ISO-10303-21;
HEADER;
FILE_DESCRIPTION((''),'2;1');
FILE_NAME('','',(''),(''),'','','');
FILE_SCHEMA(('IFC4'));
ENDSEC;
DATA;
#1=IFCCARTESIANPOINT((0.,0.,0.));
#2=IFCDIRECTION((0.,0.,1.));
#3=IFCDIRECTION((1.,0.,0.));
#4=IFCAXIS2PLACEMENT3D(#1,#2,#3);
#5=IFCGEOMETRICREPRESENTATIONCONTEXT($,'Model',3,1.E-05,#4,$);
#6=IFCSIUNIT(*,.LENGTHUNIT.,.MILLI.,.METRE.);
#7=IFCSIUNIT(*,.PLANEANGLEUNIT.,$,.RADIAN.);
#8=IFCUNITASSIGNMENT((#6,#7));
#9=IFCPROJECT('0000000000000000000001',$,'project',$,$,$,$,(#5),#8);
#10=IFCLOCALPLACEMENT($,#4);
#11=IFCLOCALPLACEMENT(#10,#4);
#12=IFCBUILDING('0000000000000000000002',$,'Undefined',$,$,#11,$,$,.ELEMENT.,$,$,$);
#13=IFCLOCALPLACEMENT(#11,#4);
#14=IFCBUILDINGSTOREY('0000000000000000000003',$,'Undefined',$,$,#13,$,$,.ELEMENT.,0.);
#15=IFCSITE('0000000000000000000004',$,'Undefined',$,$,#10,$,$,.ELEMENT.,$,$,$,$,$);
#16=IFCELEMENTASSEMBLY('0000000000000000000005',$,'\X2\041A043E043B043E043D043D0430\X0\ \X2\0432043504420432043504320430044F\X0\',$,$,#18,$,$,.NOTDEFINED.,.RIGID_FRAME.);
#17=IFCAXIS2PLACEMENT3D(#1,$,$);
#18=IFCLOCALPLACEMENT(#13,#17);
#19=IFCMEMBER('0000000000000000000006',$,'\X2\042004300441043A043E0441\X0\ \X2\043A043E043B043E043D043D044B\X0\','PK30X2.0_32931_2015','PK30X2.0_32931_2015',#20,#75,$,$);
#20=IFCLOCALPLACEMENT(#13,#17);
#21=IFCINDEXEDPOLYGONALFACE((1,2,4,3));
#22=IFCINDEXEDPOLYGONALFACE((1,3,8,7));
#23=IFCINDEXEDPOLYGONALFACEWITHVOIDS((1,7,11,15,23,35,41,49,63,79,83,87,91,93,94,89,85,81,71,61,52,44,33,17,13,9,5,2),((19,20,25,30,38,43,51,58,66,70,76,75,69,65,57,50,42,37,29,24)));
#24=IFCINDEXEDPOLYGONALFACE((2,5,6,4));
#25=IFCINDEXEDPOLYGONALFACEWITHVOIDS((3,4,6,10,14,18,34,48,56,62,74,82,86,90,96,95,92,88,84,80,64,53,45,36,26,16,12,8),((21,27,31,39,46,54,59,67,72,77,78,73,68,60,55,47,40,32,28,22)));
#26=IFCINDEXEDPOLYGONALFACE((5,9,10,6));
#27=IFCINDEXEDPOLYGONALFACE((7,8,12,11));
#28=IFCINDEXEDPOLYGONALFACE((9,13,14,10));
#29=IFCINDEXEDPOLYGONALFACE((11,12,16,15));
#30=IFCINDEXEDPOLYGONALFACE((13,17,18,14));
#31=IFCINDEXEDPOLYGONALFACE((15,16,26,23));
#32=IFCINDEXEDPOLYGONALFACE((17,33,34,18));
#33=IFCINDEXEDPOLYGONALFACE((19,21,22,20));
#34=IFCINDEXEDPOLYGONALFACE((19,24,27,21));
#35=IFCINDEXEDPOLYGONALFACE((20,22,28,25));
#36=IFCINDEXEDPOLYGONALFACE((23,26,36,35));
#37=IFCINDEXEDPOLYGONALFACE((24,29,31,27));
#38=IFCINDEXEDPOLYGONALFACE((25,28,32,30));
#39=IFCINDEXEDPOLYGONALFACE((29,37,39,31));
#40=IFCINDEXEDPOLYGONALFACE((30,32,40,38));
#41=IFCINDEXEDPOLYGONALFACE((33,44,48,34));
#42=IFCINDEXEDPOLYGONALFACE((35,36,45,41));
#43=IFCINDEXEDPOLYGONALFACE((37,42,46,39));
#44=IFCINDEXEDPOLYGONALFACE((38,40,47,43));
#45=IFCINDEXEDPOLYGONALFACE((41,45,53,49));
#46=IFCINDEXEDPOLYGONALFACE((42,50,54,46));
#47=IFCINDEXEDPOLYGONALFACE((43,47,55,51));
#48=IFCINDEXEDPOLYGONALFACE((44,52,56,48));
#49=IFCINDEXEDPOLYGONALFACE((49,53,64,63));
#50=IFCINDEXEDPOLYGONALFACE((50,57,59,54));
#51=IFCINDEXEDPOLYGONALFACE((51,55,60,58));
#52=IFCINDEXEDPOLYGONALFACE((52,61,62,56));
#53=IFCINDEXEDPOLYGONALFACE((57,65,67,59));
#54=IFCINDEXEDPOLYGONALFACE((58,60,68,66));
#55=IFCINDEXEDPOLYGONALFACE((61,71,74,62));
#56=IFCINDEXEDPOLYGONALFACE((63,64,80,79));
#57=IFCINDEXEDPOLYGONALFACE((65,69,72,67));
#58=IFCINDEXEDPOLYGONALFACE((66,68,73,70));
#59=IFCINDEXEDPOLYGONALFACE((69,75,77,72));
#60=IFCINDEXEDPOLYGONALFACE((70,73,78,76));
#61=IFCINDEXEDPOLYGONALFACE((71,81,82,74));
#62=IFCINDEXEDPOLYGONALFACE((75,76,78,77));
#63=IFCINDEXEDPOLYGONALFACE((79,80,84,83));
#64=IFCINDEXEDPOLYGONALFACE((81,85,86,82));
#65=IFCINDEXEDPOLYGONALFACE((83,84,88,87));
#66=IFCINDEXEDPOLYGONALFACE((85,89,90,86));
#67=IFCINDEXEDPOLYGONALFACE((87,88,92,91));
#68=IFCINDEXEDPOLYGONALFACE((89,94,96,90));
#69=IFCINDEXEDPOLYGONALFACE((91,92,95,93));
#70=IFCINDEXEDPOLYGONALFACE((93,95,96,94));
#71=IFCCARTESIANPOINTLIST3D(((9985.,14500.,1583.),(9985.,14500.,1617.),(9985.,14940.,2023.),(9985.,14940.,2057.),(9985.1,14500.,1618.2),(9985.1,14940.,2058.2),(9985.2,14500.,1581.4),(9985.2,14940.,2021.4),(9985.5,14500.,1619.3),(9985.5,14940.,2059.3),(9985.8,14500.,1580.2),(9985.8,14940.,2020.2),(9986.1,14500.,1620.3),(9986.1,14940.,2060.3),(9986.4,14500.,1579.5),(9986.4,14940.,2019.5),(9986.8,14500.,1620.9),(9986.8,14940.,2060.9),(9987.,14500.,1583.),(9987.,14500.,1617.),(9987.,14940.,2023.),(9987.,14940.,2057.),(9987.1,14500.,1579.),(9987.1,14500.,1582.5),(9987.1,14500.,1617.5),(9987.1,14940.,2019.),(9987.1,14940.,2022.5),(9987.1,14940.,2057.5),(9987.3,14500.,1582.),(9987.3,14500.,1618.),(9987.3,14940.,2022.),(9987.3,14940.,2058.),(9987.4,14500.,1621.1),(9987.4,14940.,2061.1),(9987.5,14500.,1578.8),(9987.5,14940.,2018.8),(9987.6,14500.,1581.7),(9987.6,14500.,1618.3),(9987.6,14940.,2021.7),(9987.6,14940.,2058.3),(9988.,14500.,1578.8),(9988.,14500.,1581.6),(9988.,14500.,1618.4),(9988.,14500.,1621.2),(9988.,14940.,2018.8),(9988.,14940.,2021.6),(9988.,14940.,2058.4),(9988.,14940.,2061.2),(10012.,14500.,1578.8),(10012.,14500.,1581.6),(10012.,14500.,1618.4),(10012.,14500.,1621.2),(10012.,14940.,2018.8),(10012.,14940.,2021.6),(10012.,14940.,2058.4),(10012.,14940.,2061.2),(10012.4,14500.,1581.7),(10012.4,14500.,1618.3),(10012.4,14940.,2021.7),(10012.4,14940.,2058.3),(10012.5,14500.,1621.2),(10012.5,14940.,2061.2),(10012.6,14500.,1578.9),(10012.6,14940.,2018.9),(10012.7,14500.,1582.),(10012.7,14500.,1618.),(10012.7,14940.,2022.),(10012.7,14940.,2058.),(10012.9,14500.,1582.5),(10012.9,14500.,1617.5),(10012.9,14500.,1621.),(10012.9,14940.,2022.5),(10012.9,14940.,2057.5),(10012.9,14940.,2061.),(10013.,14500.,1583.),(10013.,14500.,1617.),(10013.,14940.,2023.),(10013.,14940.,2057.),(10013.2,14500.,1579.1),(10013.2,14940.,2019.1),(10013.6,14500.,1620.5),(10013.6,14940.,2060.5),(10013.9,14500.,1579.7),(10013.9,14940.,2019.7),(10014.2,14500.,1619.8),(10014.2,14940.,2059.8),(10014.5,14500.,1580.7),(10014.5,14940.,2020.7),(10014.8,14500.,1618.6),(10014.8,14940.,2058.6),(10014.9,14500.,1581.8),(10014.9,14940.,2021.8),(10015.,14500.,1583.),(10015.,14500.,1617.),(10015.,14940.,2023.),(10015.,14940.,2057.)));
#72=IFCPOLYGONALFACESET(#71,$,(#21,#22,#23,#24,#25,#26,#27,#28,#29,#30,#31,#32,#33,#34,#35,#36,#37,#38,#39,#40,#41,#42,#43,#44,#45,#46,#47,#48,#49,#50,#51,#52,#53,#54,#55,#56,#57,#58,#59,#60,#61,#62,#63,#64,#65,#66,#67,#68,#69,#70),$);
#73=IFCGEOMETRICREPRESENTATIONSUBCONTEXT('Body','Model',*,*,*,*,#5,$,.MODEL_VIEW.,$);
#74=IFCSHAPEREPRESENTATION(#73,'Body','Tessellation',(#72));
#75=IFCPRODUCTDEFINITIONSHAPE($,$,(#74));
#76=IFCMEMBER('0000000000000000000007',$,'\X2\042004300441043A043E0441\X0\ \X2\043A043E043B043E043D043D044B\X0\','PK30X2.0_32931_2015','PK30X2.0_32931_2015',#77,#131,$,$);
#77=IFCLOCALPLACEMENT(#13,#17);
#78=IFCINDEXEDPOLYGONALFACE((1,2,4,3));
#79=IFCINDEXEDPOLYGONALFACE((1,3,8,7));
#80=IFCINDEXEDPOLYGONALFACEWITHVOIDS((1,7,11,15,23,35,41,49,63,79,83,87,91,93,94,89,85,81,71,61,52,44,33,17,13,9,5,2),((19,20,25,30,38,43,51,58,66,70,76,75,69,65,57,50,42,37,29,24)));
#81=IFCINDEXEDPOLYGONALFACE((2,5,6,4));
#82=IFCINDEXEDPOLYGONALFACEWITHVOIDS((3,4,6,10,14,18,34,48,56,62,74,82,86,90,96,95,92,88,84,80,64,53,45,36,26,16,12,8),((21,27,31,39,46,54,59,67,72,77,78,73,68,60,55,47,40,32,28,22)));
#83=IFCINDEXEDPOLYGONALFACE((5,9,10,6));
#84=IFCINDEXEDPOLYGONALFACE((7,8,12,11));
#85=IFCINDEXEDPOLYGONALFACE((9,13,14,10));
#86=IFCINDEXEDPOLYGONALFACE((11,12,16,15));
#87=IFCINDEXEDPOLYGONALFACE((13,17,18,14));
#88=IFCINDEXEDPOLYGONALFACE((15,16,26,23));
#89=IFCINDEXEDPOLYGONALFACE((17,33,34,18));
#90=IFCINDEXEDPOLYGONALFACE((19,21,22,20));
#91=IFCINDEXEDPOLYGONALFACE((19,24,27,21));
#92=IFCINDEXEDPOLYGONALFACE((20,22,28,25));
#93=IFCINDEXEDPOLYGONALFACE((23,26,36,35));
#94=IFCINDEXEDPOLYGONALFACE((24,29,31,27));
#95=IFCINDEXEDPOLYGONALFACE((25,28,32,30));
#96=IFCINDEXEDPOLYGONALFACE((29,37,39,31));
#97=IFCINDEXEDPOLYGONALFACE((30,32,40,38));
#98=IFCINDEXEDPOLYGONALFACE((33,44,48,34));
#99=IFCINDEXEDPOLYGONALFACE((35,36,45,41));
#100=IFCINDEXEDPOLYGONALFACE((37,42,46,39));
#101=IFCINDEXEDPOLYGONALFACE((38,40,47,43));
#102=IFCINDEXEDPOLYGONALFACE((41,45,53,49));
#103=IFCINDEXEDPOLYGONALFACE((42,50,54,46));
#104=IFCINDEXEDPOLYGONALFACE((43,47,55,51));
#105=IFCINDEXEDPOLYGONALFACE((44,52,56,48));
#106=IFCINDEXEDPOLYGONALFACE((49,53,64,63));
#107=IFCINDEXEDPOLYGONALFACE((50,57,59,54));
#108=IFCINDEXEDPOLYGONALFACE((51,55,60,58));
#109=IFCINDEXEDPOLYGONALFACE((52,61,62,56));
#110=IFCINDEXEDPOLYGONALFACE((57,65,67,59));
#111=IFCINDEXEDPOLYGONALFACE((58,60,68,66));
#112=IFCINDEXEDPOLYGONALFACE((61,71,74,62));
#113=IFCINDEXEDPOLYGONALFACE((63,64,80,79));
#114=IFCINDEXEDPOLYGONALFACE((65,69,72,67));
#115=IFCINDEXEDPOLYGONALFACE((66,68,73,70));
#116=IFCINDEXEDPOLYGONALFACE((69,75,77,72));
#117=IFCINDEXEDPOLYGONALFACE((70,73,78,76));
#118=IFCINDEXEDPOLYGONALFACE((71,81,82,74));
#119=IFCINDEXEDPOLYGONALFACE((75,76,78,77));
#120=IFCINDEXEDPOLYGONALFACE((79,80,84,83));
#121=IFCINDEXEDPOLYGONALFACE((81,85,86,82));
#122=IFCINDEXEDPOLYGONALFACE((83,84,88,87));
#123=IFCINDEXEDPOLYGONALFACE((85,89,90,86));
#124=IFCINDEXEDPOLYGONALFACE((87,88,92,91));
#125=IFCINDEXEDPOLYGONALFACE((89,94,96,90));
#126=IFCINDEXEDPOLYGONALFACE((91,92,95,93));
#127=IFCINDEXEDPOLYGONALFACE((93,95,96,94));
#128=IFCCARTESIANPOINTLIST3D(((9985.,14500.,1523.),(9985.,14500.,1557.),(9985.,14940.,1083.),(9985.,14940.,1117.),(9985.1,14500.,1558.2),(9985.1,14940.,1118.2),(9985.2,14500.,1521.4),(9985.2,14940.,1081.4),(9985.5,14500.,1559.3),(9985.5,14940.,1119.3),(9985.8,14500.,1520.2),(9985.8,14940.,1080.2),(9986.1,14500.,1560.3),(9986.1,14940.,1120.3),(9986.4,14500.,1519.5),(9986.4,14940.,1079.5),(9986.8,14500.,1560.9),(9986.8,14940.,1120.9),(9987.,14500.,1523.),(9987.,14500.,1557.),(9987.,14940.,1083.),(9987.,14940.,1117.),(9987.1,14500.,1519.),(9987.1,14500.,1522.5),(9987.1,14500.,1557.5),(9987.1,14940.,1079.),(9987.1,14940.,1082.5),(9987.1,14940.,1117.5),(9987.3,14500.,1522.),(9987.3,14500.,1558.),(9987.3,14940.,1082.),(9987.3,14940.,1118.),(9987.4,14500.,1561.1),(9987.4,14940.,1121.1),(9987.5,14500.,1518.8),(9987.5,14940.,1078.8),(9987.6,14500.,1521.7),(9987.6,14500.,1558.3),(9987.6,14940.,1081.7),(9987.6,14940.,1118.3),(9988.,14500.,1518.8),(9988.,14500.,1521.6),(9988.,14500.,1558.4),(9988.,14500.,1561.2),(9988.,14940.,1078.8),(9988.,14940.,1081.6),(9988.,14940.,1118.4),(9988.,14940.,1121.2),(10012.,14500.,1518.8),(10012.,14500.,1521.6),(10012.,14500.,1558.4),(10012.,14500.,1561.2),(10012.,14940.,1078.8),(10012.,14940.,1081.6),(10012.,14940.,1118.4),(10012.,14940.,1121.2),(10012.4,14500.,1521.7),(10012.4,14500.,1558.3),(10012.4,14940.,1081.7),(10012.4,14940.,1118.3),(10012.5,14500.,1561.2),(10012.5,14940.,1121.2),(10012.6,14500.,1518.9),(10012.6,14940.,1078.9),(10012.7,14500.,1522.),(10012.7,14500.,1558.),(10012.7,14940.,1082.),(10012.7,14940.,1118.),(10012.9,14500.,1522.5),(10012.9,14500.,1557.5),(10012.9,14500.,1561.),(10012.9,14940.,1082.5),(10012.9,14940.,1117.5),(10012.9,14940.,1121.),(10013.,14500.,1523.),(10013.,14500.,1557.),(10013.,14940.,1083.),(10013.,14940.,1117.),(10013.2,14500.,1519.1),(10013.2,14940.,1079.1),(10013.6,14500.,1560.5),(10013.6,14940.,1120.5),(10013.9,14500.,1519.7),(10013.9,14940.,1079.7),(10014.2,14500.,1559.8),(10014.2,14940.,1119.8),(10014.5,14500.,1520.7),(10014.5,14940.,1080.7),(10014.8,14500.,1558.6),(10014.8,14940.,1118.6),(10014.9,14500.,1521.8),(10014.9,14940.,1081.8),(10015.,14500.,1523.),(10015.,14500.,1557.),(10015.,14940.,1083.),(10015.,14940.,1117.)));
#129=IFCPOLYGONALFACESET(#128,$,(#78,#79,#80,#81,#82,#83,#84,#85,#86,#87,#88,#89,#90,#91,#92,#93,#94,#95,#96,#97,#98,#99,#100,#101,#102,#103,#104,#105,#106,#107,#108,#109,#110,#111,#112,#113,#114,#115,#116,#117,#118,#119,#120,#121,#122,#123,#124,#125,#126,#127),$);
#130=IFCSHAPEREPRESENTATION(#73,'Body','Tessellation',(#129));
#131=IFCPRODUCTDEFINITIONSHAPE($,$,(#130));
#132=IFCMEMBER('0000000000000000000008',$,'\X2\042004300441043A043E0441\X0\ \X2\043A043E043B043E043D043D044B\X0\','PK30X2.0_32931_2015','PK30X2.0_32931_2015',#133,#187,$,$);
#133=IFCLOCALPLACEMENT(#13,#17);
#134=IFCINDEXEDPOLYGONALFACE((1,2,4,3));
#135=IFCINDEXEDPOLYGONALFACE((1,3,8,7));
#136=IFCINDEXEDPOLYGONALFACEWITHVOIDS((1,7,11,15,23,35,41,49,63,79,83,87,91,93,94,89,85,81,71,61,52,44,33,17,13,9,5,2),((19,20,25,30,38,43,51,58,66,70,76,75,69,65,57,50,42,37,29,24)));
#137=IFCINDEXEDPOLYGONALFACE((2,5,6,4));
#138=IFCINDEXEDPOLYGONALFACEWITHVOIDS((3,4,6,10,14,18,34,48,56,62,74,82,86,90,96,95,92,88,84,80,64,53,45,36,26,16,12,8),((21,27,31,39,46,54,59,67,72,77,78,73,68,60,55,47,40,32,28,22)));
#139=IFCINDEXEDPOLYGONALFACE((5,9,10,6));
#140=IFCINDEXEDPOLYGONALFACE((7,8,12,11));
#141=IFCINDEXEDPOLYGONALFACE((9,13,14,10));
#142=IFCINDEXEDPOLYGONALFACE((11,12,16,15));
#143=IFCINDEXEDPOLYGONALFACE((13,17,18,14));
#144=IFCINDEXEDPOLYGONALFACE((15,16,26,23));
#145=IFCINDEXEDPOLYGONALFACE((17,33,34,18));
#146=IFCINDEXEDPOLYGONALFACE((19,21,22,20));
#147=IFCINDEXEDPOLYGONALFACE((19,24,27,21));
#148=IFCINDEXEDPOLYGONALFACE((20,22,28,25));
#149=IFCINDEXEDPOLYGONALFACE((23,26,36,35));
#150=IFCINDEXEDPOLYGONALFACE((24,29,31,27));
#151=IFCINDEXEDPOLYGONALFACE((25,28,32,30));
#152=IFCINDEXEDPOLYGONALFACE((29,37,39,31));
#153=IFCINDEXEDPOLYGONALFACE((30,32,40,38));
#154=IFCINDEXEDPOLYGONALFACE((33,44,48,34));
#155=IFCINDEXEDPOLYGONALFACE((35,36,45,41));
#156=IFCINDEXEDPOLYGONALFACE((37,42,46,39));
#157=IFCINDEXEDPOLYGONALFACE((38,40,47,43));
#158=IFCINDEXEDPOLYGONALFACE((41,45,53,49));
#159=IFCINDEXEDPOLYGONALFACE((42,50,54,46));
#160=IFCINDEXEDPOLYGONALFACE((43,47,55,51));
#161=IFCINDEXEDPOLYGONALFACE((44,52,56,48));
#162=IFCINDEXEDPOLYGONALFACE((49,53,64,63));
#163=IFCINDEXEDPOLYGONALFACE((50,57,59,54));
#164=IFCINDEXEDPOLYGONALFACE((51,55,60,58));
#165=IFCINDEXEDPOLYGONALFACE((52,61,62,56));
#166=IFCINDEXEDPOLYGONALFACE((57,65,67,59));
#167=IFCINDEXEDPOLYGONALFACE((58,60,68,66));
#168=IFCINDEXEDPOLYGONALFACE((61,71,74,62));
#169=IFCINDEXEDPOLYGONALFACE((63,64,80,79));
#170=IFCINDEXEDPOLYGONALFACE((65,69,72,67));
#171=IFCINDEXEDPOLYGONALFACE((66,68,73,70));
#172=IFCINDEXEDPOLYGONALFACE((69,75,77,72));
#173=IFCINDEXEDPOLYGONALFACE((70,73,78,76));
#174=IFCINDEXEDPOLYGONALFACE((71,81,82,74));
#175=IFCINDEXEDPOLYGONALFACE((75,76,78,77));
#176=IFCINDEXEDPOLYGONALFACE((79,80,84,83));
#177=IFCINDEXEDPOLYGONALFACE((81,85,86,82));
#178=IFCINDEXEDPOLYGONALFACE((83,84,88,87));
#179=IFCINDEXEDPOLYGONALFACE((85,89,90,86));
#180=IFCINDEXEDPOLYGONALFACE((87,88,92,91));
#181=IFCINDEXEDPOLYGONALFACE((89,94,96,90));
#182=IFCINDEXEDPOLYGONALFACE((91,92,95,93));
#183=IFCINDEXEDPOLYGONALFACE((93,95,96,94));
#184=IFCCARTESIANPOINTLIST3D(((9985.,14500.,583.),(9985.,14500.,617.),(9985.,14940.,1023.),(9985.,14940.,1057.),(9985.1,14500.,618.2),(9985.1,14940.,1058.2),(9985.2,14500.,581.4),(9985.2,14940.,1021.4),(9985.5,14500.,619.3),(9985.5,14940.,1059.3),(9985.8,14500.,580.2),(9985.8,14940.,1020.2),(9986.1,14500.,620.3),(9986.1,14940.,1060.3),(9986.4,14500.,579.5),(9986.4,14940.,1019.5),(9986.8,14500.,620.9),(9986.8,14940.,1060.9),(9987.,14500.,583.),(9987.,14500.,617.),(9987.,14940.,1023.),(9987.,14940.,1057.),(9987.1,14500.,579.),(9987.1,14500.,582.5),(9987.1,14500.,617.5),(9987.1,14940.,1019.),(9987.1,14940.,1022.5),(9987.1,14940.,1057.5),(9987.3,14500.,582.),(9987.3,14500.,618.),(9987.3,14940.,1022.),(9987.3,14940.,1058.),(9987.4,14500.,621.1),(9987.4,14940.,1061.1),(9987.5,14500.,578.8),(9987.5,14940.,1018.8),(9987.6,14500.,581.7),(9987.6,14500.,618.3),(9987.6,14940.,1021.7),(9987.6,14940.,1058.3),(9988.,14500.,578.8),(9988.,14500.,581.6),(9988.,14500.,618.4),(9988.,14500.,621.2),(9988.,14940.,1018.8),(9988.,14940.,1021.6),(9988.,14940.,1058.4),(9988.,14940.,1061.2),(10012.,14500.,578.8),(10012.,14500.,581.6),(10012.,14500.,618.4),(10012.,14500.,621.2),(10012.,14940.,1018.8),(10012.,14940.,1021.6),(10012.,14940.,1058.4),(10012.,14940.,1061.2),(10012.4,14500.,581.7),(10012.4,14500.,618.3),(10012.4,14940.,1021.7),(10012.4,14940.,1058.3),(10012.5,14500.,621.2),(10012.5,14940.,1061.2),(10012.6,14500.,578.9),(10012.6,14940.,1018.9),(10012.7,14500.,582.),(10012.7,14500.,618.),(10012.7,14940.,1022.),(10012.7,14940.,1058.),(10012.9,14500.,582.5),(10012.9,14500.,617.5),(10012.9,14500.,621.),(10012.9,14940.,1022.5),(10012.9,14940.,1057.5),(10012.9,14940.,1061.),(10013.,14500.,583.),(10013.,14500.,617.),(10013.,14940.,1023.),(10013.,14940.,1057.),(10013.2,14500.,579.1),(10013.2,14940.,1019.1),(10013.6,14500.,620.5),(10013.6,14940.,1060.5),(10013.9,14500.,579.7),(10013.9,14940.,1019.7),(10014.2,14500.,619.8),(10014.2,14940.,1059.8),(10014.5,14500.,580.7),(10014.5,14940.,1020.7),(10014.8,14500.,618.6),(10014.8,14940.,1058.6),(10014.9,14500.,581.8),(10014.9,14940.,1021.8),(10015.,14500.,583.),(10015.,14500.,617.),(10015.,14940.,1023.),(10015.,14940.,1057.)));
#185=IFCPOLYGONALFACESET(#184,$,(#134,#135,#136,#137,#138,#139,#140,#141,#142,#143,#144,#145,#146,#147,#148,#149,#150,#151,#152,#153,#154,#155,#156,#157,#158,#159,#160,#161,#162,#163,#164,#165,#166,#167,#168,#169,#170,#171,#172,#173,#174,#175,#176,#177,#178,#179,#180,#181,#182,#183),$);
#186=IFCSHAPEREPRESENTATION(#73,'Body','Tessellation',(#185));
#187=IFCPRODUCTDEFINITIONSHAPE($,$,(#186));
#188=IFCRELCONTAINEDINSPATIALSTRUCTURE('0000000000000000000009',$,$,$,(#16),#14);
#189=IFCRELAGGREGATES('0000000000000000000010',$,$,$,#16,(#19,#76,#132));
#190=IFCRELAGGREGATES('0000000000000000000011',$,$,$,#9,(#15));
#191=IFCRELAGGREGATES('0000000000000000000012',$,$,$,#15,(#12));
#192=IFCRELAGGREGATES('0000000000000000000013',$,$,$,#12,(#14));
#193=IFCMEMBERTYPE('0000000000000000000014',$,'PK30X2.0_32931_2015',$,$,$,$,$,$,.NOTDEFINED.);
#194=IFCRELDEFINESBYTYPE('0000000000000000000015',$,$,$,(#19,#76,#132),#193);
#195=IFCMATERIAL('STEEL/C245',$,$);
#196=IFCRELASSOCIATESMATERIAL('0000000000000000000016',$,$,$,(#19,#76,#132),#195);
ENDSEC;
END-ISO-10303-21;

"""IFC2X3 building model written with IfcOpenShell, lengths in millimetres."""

from ifc_helpers import new_model, si_unit, frame, origin_with_axes, origin_2d_with_axis, place, context, subcontext, project, spatial, hollow_rectangle, extrude, clip, halfspace, material, type_object, element, aggregate, save


model = new_model("IFC2X3")

# Units and contexts
model_context = context("Model", 3, precision=1e-05, world=origin_with_axes())
body_context = subcontext(model_context, "Body", "Model", "MODEL_VIEW")
ifc_project = project(units=[si_unit("LENGTHUNIT", "METRE", prefix="MILLI"), si_unit("PLANEANGLEUNIT", "RADIAN")], contexts=[model_context])

# Site, building, storey
site_placement = place(None, origin_with_axes())
site = spatial("IfcSite", under=ifc_project, at=site_placement, Name="Undefined", CompositionType="ELEMENT")
building_placement = place(site_placement, origin_with_axes())
building = spatial("IfcBuilding", under=site, at=building_placement, Name="Undefined", CompositionType="ELEMENT")
storey_placement = place(building_placement, origin_with_axes())
storey = spatial("IfcBuildingStorey", under=building, at=storey_placement, Name="Undefined", CompositionType="ELEMENT", Elevation=0.0)

# Element assembly
assembly_1_placement = place(storey_placement, origin_with_axes())
assembly_1 = element("IfcElementAssembly", 1, at=assembly_1_placement, inside=storey, Name="Колонна ветвевая", AssemblyPlace="NOTDEFINED", PredefinedType="RIGID_FRAME")
ifc_material_1 = material(Name="STEEL/C245")

# Members
member_type_1 = type_object("IfcMemberType", Name="PK30X2.0_32931_2015", PredefinedType="NOTDEFINED")
member_1_placement = place(assembly_1_placement, frame((10000.0, 14470.0, 1570.0), z_axis=(0.0, -0.707107, 0.707107), x_axis=(0.0, 0.707107, 0.707107)))
member_1 = element("IfcMember", 2, at=member_1_placement, type_object=member_type_1, material=ifc_material_1, Name="Раскос колонны", Description="PK30X2.0_32931_2015", ObjectType="PK30X2.0_32931_2015", context=body_context, shape_type="Clipping", body=[
    clip(clip(extrude(hollow_rectangle(XDim=30.0, YDim=30.0, WallThickness=2.0, InnerFilletRadius=1.0, OuterFilletRadius=3.0, at=origin_2d_with_axis()), frame((695.0, 0.0, 0.0), z_axis=(-1.0, 0.0, 0.0), x_axis=(0.0, -1.0, 0.0)), (0.0, 0.0, 1.0), 682.9), halfspace(frame((629.0, 0.0, -35.7), z_axis=(-0.707107, 0.0, 0.707107), x_axis=(0.707107, 0.0, 0.707107)), True)), halfspace(frame((65.2, 0.0, 22.8), z_axis=(-0.707107, 0.0, 0.707107), x_axis=(0.707107, 0.0, 0.707107)), False)),
])
member_2_placement = place(assembly_1_placement, frame((10000.0, 14470.0, 1570.0), z_axis=(0.0, -0.707107, -0.707107), x_axis=(0.0, 0.707107, -0.707107)))
member_2 = element("IfcMember", 3, at=member_2_placement, type_object=member_type_1, material=ifc_material_1, Name="Раскос колонны", Description="PK30X2.0_32931_2015", ObjectType="PK30X2.0_32931_2015", context=body_context, shape_type="Clipping", body=[
    clip(clip(extrude(hollow_rectangle(XDim=30.0, YDim=30.0, WallThickness=2.0, InnerFilletRadius=1.0, OuterFilletRadius=3.0, at=origin_2d_with_axis()), frame((695.0, 0.0, 0.0), z_axis=(-1.0, 0.0, 0.0), x_axis=(0.0, -1.0, 0.0)), (0.0, 0.0, 1.0), 682.9), halfspace(frame((629.0, 0.0, -35.7), z_axis=(-0.707107, 0.0, 0.707107), x_axis=(0.707107, 0.0, 0.707107)), True)), halfspace(frame((65.2, 0.0, 22.8), z_axis=(-0.707107, 0.0, 0.707107), x_axis=(0.707107, 0.0, 0.707107)), False)),
])
member_3_placement = place(assembly_1_placement, frame((10000.0, 14470.0, 570.0), z_axis=(0.0, -0.707107, 0.707107), x_axis=(0.0, 0.707107, 0.707107)))
member_3 = element("IfcMember", 4, at=member_3_placement, type_object=member_type_1, material=ifc_material_1, Name="Раскос колонны", Description="PK30X2.0_32931_2015", ObjectType="PK30X2.0_32931_2015", context=body_context, shape_type="Clipping", body=[
    clip(clip(extrude(hollow_rectangle(XDim=30.0, YDim=30.0, WallThickness=2.0, InnerFilletRadius=1.0, OuterFilletRadius=3.0, at=origin_2d_with_axis()), frame((695.0, 0.0, 0.0), z_axis=(-1.0, 0.0, 0.0), x_axis=(0.0, -1.0, 0.0)), (0.0, 0.0, 1.0), 682.9), halfspace(frame((629.0, 0.0, -35.7), z_axis=(-0.707107, 0.0, 0.707107), x_axis=(0.707107, 0.0, 0.707107)), True)), halfspace(frame((65.2, 0.0, 22.8), z_axis=(-0.707107, 0.0, 0.707107), x_axis=(0.707107, 0.0, 0.707107)), False)),
])

aggregate(assembly_1, [member_1, member_2, member_3])

save(model, "model.ifc")
